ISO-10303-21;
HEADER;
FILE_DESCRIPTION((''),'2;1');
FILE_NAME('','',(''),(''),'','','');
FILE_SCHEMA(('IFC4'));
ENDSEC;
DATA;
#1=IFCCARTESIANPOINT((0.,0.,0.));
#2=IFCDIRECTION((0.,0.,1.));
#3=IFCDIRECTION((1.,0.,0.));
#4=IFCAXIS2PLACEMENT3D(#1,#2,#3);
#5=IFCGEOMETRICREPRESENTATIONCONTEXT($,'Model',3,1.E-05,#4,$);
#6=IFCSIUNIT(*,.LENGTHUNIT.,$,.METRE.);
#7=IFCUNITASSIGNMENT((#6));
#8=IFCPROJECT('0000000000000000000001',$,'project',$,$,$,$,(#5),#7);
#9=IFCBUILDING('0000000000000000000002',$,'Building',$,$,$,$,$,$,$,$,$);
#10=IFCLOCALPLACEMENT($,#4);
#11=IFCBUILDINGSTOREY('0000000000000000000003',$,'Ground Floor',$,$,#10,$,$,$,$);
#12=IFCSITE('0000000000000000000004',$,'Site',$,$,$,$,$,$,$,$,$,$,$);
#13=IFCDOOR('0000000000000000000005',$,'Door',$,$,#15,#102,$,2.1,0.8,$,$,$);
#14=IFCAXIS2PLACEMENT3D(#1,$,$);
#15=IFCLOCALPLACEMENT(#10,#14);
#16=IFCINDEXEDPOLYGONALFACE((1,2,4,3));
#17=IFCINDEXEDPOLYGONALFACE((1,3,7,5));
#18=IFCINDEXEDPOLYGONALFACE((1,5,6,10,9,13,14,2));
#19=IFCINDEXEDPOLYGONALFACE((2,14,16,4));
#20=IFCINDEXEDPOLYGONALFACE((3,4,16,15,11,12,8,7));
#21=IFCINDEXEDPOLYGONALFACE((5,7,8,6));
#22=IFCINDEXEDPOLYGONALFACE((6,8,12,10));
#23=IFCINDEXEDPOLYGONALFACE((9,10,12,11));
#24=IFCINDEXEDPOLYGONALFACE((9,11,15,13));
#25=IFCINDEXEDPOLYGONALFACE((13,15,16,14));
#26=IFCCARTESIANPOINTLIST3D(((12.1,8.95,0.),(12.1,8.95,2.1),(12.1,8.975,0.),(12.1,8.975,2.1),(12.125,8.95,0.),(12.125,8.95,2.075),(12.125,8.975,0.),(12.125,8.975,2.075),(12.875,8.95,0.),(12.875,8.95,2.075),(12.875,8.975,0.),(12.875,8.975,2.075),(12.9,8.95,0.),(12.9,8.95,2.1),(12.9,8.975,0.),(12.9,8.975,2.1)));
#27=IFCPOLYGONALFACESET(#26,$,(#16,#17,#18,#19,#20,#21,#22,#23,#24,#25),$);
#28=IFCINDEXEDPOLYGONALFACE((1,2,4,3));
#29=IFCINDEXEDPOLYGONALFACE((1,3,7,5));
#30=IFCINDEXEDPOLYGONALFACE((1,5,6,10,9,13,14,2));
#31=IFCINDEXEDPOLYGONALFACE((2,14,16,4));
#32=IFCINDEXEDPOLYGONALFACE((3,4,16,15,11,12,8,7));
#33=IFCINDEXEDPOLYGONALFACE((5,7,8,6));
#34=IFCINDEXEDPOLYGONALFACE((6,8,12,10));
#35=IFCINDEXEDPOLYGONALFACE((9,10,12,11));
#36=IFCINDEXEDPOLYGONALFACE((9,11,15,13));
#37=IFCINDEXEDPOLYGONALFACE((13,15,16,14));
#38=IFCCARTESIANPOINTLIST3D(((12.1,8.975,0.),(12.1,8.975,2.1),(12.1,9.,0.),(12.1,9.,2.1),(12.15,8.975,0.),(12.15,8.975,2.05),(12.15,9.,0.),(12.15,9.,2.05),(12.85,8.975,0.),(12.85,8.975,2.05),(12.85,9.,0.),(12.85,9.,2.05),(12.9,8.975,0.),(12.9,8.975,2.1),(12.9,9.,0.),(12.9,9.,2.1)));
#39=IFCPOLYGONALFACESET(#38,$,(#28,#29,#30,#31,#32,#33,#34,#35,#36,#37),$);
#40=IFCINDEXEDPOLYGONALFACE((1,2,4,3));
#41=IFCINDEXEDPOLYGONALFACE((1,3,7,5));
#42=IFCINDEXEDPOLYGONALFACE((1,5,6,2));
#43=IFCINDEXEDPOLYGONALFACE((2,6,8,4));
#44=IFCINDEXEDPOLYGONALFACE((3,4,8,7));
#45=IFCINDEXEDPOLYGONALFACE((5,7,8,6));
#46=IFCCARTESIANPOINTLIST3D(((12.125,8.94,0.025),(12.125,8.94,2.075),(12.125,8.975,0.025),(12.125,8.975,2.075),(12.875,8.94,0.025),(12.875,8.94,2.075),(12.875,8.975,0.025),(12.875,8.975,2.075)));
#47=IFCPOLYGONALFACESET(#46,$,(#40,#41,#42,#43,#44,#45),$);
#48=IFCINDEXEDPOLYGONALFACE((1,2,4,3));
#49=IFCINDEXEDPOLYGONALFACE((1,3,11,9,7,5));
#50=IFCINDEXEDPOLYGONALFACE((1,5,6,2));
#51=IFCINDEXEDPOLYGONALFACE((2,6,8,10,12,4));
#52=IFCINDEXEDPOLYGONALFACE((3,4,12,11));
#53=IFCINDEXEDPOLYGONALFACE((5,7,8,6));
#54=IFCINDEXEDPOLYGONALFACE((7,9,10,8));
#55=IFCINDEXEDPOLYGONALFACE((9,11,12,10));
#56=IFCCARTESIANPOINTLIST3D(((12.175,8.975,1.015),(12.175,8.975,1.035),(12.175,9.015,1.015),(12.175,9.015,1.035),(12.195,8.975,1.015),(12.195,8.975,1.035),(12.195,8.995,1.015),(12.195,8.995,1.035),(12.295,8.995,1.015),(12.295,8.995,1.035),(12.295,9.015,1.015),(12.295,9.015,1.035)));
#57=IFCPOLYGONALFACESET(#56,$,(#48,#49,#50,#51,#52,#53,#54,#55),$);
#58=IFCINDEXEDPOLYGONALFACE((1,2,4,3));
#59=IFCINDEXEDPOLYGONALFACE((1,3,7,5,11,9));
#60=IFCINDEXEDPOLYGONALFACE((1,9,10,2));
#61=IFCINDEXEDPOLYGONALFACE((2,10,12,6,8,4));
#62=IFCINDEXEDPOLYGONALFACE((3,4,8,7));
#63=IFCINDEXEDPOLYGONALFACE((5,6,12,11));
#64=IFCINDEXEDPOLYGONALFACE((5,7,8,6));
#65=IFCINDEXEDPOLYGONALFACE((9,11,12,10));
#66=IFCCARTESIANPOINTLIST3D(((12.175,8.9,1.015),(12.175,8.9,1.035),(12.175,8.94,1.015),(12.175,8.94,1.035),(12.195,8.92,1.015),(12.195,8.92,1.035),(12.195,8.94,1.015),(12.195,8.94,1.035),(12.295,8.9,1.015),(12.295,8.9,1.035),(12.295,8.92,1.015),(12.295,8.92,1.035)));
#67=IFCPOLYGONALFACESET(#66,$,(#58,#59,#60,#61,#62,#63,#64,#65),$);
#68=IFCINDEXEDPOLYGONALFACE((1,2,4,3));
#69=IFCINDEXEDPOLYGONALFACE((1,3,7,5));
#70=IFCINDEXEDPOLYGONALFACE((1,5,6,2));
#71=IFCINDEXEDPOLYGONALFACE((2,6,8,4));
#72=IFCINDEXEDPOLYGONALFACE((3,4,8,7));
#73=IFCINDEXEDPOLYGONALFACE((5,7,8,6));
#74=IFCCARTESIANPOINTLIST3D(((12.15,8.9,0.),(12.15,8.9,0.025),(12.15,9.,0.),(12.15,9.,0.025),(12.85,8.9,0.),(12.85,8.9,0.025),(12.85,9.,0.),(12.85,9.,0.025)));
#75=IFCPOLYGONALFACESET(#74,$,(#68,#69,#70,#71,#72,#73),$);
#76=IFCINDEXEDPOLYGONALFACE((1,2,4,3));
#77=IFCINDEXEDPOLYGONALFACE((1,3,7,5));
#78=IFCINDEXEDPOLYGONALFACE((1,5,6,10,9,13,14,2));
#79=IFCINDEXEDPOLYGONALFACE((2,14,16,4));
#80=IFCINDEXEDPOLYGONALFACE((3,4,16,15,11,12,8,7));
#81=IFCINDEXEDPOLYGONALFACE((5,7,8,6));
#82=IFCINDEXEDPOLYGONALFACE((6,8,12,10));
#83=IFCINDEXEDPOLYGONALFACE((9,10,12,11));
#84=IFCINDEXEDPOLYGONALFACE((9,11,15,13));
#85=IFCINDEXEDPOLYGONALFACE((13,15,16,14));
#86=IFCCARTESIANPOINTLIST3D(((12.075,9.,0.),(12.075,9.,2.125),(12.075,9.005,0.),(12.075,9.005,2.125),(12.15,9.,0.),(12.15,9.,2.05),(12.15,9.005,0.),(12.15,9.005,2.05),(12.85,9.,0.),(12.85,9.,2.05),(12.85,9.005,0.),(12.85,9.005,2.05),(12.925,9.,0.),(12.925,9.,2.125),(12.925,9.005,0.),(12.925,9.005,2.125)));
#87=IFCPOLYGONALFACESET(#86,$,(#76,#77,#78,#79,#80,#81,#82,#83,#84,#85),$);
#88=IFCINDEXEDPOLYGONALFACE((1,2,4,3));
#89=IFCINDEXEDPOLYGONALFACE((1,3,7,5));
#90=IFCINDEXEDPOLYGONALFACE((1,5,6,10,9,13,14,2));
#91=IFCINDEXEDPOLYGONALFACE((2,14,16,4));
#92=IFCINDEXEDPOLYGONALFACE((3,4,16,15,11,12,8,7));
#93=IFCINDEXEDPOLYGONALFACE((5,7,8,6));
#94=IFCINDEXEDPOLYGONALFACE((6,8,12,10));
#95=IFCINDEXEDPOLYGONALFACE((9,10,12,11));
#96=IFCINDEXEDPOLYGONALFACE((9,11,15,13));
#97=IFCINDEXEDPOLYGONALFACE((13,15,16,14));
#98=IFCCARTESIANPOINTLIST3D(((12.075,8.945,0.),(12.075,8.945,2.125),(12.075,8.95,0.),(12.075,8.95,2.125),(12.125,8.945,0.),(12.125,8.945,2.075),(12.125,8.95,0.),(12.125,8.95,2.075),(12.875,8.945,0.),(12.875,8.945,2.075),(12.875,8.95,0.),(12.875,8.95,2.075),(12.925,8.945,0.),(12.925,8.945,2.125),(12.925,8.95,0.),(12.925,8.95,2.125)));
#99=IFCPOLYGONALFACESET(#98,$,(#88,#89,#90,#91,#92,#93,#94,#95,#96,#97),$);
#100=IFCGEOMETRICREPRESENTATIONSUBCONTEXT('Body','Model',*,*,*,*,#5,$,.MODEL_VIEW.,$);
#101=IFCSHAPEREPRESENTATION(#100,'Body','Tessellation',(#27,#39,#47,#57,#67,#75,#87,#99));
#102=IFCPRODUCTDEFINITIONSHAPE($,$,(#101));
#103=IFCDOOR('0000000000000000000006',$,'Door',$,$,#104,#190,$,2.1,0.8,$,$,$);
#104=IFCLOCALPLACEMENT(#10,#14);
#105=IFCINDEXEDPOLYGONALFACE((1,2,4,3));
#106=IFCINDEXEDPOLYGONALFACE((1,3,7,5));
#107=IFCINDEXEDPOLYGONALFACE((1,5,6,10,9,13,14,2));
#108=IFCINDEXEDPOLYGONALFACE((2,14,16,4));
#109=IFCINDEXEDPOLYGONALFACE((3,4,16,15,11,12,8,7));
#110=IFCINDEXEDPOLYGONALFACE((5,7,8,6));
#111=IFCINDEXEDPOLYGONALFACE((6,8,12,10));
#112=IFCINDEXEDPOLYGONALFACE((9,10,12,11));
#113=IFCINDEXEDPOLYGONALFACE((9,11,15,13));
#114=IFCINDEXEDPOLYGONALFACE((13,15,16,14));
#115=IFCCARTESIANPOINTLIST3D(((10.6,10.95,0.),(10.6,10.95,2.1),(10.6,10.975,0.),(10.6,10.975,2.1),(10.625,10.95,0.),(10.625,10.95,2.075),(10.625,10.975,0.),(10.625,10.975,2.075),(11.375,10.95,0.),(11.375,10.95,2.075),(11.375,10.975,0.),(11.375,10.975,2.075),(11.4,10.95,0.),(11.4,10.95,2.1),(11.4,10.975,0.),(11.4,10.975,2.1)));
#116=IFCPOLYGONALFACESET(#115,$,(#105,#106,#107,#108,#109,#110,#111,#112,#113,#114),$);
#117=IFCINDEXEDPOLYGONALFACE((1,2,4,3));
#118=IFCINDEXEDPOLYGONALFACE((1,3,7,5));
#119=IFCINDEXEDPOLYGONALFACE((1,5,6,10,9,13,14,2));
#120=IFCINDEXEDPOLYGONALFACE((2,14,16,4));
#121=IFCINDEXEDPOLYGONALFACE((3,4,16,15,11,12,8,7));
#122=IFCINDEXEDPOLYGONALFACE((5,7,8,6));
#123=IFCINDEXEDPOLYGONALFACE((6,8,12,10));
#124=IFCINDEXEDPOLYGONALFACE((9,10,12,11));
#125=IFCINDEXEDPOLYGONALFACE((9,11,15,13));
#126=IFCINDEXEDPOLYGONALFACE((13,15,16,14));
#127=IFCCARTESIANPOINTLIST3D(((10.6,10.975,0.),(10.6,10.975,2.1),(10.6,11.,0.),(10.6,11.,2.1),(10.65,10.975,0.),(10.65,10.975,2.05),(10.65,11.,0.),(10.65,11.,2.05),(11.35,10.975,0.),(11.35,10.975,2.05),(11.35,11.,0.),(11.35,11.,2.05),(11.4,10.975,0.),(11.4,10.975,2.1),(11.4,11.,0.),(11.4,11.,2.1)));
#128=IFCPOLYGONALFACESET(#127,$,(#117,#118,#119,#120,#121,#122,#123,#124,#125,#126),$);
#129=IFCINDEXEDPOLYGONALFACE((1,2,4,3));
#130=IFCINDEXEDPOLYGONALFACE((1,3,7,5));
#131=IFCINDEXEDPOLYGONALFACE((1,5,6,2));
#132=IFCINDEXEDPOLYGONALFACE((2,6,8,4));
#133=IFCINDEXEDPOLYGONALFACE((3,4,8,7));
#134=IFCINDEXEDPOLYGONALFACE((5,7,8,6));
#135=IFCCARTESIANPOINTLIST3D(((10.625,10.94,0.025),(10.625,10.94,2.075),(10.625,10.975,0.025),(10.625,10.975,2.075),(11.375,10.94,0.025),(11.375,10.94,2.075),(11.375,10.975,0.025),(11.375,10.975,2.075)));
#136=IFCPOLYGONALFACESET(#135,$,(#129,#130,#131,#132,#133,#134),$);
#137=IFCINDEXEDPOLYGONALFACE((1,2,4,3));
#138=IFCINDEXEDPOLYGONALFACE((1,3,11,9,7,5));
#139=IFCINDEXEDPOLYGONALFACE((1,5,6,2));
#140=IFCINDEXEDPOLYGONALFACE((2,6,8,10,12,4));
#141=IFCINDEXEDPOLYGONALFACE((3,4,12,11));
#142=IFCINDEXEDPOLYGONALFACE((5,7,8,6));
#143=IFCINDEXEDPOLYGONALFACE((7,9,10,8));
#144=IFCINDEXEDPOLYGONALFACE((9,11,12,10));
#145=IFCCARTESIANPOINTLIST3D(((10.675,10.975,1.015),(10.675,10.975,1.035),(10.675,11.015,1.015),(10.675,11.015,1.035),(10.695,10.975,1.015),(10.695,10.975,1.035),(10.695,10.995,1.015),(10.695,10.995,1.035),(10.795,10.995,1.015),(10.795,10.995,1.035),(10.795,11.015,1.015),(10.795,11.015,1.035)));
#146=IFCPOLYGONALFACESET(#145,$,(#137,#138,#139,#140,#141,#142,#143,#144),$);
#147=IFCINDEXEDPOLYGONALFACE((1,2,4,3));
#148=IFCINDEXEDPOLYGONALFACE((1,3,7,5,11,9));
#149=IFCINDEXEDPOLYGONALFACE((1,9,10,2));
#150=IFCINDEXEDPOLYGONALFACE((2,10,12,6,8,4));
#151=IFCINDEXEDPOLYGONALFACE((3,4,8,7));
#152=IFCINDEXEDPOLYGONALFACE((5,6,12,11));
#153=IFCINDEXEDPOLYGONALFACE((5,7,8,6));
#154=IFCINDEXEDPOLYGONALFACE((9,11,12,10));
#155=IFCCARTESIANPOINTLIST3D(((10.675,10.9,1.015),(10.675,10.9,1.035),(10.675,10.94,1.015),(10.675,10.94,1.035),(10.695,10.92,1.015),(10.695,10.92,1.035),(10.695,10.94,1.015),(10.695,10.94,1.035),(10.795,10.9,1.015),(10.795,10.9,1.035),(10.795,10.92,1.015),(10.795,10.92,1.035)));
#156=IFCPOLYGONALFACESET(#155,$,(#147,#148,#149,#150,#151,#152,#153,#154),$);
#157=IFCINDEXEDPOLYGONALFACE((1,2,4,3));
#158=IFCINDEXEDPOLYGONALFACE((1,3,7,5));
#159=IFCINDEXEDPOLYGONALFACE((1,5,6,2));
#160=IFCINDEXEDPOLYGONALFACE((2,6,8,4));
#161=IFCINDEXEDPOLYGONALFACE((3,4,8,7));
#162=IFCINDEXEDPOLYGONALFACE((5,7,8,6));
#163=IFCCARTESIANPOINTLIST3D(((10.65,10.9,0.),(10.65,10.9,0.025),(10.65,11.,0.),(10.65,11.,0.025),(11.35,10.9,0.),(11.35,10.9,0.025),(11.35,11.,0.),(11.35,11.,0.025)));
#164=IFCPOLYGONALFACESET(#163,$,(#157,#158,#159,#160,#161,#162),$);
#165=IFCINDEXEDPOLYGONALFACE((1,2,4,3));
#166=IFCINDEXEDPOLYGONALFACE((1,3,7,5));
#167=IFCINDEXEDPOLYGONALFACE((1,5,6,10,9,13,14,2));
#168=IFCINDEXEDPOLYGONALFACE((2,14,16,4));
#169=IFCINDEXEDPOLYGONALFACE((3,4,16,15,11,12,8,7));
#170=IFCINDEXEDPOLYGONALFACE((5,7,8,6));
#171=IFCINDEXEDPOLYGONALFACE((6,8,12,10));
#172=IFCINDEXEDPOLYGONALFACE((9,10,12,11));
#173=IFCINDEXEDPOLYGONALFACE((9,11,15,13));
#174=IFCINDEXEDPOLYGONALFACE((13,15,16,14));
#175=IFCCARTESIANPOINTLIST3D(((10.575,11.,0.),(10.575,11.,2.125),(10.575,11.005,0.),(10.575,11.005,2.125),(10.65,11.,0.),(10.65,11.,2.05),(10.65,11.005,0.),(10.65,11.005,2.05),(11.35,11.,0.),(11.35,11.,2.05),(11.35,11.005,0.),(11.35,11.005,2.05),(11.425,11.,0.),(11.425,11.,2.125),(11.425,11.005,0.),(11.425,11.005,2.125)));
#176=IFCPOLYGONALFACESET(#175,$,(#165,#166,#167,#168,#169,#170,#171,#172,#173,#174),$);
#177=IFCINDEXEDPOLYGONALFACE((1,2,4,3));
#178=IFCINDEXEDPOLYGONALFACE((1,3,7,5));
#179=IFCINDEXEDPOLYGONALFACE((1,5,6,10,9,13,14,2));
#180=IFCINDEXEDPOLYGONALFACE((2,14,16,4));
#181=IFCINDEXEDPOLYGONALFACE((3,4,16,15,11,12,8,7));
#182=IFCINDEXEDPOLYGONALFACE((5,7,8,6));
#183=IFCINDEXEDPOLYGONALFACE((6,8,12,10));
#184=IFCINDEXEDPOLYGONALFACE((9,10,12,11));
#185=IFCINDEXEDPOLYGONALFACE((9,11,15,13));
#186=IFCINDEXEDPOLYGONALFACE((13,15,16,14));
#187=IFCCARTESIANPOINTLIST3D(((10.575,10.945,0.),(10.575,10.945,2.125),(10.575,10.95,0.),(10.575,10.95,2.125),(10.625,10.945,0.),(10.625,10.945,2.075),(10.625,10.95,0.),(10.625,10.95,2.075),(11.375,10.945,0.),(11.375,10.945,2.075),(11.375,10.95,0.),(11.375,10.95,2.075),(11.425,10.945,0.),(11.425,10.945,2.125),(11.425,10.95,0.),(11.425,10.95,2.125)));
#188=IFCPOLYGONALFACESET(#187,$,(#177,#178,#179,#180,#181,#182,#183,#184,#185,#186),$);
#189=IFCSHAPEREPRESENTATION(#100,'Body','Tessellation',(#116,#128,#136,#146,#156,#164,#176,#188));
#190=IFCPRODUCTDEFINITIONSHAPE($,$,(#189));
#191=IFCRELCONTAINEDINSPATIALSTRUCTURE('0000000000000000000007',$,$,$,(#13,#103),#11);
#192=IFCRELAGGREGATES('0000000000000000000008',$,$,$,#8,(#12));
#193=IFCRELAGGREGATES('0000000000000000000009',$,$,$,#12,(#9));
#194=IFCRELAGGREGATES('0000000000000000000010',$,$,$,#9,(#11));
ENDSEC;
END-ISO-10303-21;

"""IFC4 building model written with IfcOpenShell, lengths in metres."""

from ifc_helpers import new_model, si_unit, frame, origin_with_axes, place, context, subcontext, project, spatial, line, indexed_curve, outline, extrude, element, save


model = new_model("IFC4")

# Units and contexts
model_context = context("Model", 3, precision=1e-05, world=origin_with_axes())
body_context = subcontext(model_context, "Body", "Model", "MODEL_VIEW")
ifc_project = project(units=[si_unit("LENGTHUNIT", "METRE")], contexts=[model_context])

# Site, building, storey
site = spatial("IfcSite", under=ifc_project, Name="Site")
building = spatial("IfcBuilding", under=site, Name="Building")
storey_placement = place(None, origin_with_axes())
storey = spatial("IfcBuildingStorey", under=building, at=storey_placement, Name="Ground Floor")

# Doors
door_1_placement = place(storey_placement, frame((12.9, 9.0, 0.0), z_axis=(0.0, 0.0, 1.0), x_axis=(-1.0, 0.0, 0.0)))
element("IfcDoor", 1, at=door_1_placement, inside=storey, Name="Door", OverallHeight=2.1, OverallWidth=0.8, context=body_context, shape_type="SweptSolid", body=[
    extrude(outline(indexed_curve([(0.0, 0.0), (0.0, 2.1), (0.8, 2.1), (0.8, 0.0), (0.775, 0.0), (0.775, 2.075), (0.025, 2.075), (0.025, 0.0)], segments=[line(1, 2, 3, 4, 5, 6, 7, 8, 1)])), frame((0.0, 0.025, 0.0), z_axis=(0.0, -1.0, 0.0), x_axis=(1.0, 0.0, 0.0)), (0.0, 0.0, -1.0), 0.025),
    extrude(outline(indexed_curve([(0.0, 0.0), (0.0, 2.1), (0.8, 2.1), (0.8, 0.0), (0.75, 0.0), (0.75, 2.05), (0.05, 2.05), (0.05, 0.0)], segments=[line(1, 2, 3, 4, 5, 6, 7, 8, 1)])), frame((0.0, 0.0, 0.0), z_axis=(0.0, -1.0, 0.0), x_axis=(1.0, 0.0, 0.0)), (0.0, 0.0, -1.0), 0.025),
    extrude(outline(indexed_curve([(0.0, 0.0), (0.75, 0.0), (0.75, 0.035), (0.0, 0.035)], segments=[line(1, 2, 3, 4, 1)])), frame((0.025, 0.025, 0.025), z_axis=(0.0, 0.0, 1.0), x_axis=(1.0, 0.0, 0.0)), (0.0, 0.0, 1.0), 2.05),
    extrude(outline(indexed_curve([(0.0, 0.0), (0.0, -0.04), (-0.12, -0.04), (-0.12, -0.02), (-0.02, -0.02), (-0.02, 0.0)], segments=[line(1, 2, 3, 4, 5, 6, 1)])), frame((0.725, 0.025, 1.015), z_axis=(0.0, 0.0, 1.0), x_axis=(1.0, 0.0, 0.0)), (0.0, 0.0, 1.0), 0.02),
    extrude(outline(indexed_curve([(0.0, 0.0), (0.0, 0.04), (-0.12, 0.04), (-0.12, 0.02), (-0.02, 0.02), (-0.02, 0.0)], segments=[line(1, 2, 3, 4, 5, 6, 1)])), frame((0.725, 0.06, 1.015), z_axis=(0.0, 0.0, 1.0), x_axis=(1.0, 0.0, 0.0)), (0.0, 0.0, 1.0), 0.02),
    extrude(outline(indexed_curve([(0.0, 0.0), (0.7, 0.0), (0.7, 0.1), (0.0, 0.1)], segments=[line(1, 2, 3, 4, 1)])), frame((0.05, 0.0, 0.0), z_axis=(0.0, 0.0, 1.0), x_axis=(1.0, 0.0, 0.0)), (0.0, 0.0, 1.0), 0.025),
    extrude(outline(indexed_curve([(0.0, 0.0), (0.0, 2.125), (0.85, 2.125), (0.85, 0.0), (0.775, 0.0), (0.775, 2.05), (0.075, 2.05), (0.075, 0.0)], segments=[line(1, 2, 3, 4, 5, 6, 7, 8, 1)])), frame((-0.025, -0.005, 0.0), z_axis=(0.0, -1.0, 0.0), x_axis=(1.0, 0.0, 0.0)), (0.0, 0.0, -1.0), 0.005),
    extrude(outline(indexed_curve([(0.0, 0.0), (0.0, 2.125), (0.85, 2.125), (0.85, 0.0), (0.8, 0.0), (0.8, 2.075), (0.05, 2.075), (0.05, 0.0)], segments=[line(1, 2, 3, 4, 5, 6, 7, 8, 1)])), frame((-0.025, 0.05, 0.0), z_axis=(0.0, -1.0, 0.0), x_axis=(1.0, 0.0, 0.0)), (0.0, 0.0, -1.0), 0.005),
])
door_2_placement = place(storey_placement, frame((11.4, 11.0, 0.0), z_axis=(0.0, 0.0, 1.0), x_axis=(-1.0, 0.0, 0.0)))
element("IfcDoor", 2, at=door_2_placement, inside=storey, Name="Door", OverallHeight=2.1, OverallWidth=0.8, context=body_context, shape_type="SweptSolid", body=[
    extrude(outline(indexed_curve([(0.0, 0.0), (0.0, 2.1), (0.8, 2.1), (0.8, 0.0), (0.775, 0.0), (0.775, 2.075), (0.025, 2.075), (0.025, 0.0)], segments=[line(1, 2, 3, 4, 5, 6, 7, 8, 1)])), frame((0.0, 0.025, 0.0), z_axis=(0.0, -1.0, 0.0), x_axis=(1.0, 0.0, 0.0)), (0.0, 0.0, -1.0), 0.025),
    extrude(outline(indexed_curve([(0.0, 0.0), (0.0, 2.1), (0.8, 2.1), (0.8, 0.0), (0.75, 0.0), (0.75, 2.05), (0.05, 2.05), (0.05, 0.0)], segments=[line(1, 2, 3, 4, 5, 6, 7, 8, 1)])), frame((0.0, 0.0, 0.0), z_axis=(0.0, -1.0, 0.0), x_axis=(1.0, 0.0, 0.0)), (0.0, 0.0, -1.0), 0.025),
    extrude(outline(indexed_curve([(0.0, 0.0), (0.75, 0.0), (0.75, 0.035), (0.0, 0.035)], segments=[line(1, 2, 3, 4, 1)])), frame((0.025, 0.025, 0.025), z_axis=(0.0, 0.0, 1.0), x_axis=(1.0, 0.0, 0.0)), (0.0, 0.0, 1.0), 2.05),
    extrude(outline(indexed_curve([(0.0, 0.0), (0.0, -0.04), (-0.12, -0.04), (-0.12, -0.02), (-0.02, -0.02), (-0.02, 0.0)], segments=[line(1, 2, 3, 4, 5, 6, 1)])), frame((0.725, 0.025, 1.015), z_axis=(0.0, 0.0, 1.0), x_axis=(1.0, 0.0, 0.0)), (0.0, 0.0, 1.0), 0.02),
    extrude(outline(indexed_curve([(0.0, 0.0), (0.0, 0.04), (-0.12, 0.04), (-0.12, 0.02), (-0.02, 0.02), (-0.02, 0.0)], segments=[line(1, 2, 3, 4, 5, 6, 1)])), frame((0.725, 0.06, 1.015), z_axis=(0.0, 0.0, 1.0), x_axis=(1.0, 0.0, 0.0)), (0.0, 0.0, 1.0), 0.02),
    extrude(outline(indexed_curve([(0.0, 0.0), (0.7, 0.0), (0.7, 0.1), (0.0, 0.1)], segments=[line(1, 2, 3, 4, 1)])), frame((0.05, 0.0, 0.0), z_axis=(0.0, 0.0, 1.0), x_axis=(1.0, 0.0, 0.0)), (0.0, 0.0, 1.0), 0.025),
    extrude(outline(indexed_curve([(0.0, 0.0), (0.0, 2.125), (0.85, 2.125), (0.85, 0.0), (0.775, 0.0), (0.775, 2.05), (0.075, 2.05), (0.075, 0.0)], segments=[line(1, 2, 3, 4, 5, 6, 7, 8, 1)])), frame((-0.025, -0.005, 0.0), z_axis=(0.0, -1.0, 0.0), x_axis=(1.0, 0.0, 0.0)), (0.0, 0.0, -1.0), 0.005),
    extrude(outline(indexed_curve([(0.0, 0.0), (0.0, 2.125), (0.85, 2.125), (0.85, 0.0), (0.8, 0.0), (0.8, 2.075), (0.05, 2.075), (0.05, 0.0)], segments=[line(1, 2, 3, 4, 5, 6, 7, 8, 1)])), frame((-0.025, 0.05, 0.0), z_axis=(0.0, -1.0, 0.0), x_axis=(1.0, 0.0, 0.0)), (0.0, 0.0, -1.0), 0.005),
])

save(model, "model.ifc")
